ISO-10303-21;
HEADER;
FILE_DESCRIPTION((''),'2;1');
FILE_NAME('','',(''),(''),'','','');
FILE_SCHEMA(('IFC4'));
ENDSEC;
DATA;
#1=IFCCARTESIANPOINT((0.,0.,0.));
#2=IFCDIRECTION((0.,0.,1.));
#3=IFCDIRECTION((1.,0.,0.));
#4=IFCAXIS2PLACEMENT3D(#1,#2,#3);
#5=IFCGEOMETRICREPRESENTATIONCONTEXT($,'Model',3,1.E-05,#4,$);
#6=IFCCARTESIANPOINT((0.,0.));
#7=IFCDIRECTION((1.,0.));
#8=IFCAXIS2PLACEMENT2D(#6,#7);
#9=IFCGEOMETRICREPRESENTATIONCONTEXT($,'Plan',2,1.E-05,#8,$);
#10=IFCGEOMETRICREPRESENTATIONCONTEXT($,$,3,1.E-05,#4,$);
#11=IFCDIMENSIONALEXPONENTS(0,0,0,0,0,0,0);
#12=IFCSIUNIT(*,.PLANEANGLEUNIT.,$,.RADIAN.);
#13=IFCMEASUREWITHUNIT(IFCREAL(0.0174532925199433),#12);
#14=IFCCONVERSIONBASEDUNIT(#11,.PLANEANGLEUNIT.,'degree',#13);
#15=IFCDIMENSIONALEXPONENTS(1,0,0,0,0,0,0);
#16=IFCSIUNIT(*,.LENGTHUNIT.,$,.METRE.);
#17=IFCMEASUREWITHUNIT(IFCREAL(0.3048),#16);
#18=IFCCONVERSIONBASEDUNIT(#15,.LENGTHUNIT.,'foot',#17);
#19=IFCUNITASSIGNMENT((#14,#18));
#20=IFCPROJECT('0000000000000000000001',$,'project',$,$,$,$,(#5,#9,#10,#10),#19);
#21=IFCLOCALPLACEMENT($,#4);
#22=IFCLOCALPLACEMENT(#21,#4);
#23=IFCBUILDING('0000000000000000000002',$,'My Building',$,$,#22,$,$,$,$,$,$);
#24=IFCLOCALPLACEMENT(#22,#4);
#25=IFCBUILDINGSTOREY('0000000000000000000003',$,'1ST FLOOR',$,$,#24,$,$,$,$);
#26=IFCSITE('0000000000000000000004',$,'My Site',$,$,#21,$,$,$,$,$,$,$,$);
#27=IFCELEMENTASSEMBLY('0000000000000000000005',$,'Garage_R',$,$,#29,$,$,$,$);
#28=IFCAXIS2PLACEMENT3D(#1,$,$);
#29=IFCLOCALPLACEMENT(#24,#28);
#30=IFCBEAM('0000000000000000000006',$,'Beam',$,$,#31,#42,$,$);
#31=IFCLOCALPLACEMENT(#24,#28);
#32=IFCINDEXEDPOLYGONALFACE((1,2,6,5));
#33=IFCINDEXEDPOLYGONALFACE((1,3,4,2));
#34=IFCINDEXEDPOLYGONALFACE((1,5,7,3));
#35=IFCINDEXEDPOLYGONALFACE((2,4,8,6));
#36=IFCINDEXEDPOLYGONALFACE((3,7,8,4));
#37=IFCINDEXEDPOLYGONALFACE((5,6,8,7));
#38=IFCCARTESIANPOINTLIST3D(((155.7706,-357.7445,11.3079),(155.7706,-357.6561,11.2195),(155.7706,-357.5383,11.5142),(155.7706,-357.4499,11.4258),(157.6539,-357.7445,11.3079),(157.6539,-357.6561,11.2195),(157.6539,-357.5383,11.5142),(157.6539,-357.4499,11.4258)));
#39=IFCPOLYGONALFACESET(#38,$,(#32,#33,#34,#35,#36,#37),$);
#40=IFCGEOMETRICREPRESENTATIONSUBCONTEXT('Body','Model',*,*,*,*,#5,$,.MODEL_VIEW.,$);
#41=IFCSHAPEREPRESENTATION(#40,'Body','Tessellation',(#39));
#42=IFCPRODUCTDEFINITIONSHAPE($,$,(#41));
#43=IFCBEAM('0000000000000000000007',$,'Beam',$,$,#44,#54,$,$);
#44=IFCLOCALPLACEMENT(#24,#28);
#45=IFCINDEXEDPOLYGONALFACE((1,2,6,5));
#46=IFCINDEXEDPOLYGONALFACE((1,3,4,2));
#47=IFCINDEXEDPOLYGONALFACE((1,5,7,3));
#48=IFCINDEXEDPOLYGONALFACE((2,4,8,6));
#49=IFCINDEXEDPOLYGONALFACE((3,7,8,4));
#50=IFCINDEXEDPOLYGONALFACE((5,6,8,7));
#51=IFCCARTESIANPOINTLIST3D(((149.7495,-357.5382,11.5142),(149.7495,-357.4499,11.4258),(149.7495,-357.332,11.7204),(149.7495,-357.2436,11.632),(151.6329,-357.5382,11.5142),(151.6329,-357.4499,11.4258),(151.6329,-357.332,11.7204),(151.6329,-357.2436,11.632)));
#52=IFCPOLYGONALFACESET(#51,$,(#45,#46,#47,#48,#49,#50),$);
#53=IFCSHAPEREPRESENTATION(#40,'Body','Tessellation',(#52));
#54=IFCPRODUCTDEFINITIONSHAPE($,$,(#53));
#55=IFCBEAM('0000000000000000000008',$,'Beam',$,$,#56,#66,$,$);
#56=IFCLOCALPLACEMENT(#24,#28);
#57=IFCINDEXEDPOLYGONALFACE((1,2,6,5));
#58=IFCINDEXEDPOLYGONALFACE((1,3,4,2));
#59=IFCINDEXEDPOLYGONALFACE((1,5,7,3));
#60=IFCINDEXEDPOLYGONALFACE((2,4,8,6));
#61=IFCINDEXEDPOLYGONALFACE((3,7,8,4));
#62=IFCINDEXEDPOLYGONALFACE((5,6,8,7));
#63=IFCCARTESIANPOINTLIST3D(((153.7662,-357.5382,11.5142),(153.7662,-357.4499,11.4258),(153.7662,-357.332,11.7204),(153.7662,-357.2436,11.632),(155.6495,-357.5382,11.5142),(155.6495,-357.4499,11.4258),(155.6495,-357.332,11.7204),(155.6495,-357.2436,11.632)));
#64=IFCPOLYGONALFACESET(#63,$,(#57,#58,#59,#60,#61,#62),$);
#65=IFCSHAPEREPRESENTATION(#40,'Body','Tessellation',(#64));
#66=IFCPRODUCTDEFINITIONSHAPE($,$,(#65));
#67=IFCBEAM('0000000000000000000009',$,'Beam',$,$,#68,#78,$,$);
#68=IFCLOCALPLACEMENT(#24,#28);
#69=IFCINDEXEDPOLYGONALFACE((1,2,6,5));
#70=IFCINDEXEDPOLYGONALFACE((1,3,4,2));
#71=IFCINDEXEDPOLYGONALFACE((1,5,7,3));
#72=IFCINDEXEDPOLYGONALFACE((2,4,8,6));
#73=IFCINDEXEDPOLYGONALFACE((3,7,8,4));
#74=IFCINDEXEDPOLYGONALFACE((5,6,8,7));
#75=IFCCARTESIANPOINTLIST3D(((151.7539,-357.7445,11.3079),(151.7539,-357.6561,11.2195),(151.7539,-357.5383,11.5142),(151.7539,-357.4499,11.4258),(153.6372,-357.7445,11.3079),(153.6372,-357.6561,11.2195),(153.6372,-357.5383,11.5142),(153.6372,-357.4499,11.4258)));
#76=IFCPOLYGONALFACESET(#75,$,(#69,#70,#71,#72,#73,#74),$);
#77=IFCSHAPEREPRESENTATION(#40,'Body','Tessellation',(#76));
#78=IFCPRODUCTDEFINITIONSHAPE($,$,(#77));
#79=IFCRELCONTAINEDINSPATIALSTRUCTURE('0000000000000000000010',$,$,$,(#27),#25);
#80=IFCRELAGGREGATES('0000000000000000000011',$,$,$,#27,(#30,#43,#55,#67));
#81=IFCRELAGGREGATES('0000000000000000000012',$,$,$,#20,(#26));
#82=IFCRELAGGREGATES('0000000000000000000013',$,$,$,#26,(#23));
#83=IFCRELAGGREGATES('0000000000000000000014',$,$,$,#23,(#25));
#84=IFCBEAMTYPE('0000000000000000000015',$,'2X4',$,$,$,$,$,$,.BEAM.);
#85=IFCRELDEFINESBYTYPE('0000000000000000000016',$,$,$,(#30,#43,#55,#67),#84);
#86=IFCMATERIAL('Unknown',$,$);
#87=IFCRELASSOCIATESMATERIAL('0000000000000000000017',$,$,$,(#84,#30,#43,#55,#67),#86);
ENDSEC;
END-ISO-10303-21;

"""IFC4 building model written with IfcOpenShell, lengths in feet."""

from ifc_helpers import new_model, entity, si_unit, converted_unit, frame, origin_with_axes, origin_2d_with_axis, place, context, subcontext, project, spatial, rectangle, extrude, material, material_profile, profile_set, profile_usage, type_object, element, aggregate, save


model = new_model("IFC4")

# Units and contexts
model_context = context("Model", 3, precision=1e-05, world=origin_with_axes())
plan_context = context("Plan", 2, precision=1e-05, world=origin_2d_with_axis())
context_of_model = context(None, 3, precision=1e-05, world=origin_with_axes())
body_context = subcontext(model_context, "Body", "Model", "MODEL_VIEW")
ifc_project = project(units=[converted_unit("PLANEANGLEUNIT", "degree", entity("IfcReal", 0.0174532925199433), si_unit("PLANEANGLEUNIT", "RADIAN"), dimensions=[0, 0, 0, 0, 0, 0, 0]), converted_unit("LENGTHUNIT", "foot", entity("IfcReal", 0.3048), si_unit("LENGTHUNIT", "METRE"), dimensions=[1, 0, 0, 0, 0, 0, 0])], contexts=[model_context, plan_context, context_of_model, context_of_model])

# Site, building, storey
site_placement = place(None, origin_with_axes())
site = spatial("IfcSite", under=ifc_project, at=site_placement, Name="My Site")
building_placement = place(site_placement, origin_with_axes())
building = spatial("IfcBuilding", under=site, at=building_placement, Name="My Building")
storey_placement = place(building_placement, origin_with_axes())
storey = spatial("IfcBuildingStorey", under=building, at=storey_placement, Name="1ST FLOOR")

# Element assembly, beams
ifc_material_1 = material(Name="Unknown")
ifc_material_profile_1 = material_profile(ifc_material_1, rectangle(XDim=0.125, YDim=0.2917))
ifc_profile_set_1 = profile_set([ifc_material_profile_1])
beam_type_1 = type_object("IfcBeamType", Name="2X4", PredefinedType="BEAM", material=ifc_profile_set_1)
assembly_1_placement = place(storey_placement, origin_with_axes())
assembly_1 = element("IfcElementAssembly", 1, at=assembly_1_placement, inside=storey, Name="Garage_R")
ifc_profile_usage_1 = profile_usage(ifc_profile_set_1, cardinal=5)
beam_1_placement = place(assembly_1_placement, frame((155.7706, -357.5972, 11.3668), z_axis=(1.0, -0.000001, 0.0), x_axis=(0.0, -0.707107, 0.707107)))
beam_1 = element("IfcBeam", 2, at=beam_1_placement, type_object=beam_type_1, material=ifc_profile_usage_1, Name="Beam", context=body_context, shape_type="SweptSolid", body=[
    extrude(rectangle(XDim=0.125, YDim=0.2917), origin_with_axes(), (0.0, 0.0, 1.0), 1.8833),
])
ifc_profile_usage_2 = profile_usage(ifc_profile_set_1, cardinal=5)
beam_2_placement = place(assembly_1_placement, frame((149.7495, -357.3909, 11.5731), z_axis=(1.0, -0.000001, 0.0), x_axis=(0.0, -0.707107, 0.707107)))
beam_2 = element("IfcBeam", 3, at=beam_2_placement, type_object=beam_type_1, material=ifc_profile_usage_2, Name="Beam", context=body_context, shape_type="SweptSolid", body=[
    extrude(rectangle(XDim=0.125, YDim=0.2917), origin_with_axes(), (0.0, 0.0, 1.0), 1.8833),
])
ifc_profile_usage_3 = profile_usage(ifc_profile_set_1, cardinal=5)
beam_3_placement = place(assembly_1_placement, frame((153.7662, -357.3909, 11.5731), z_axis=(1.0, -0.000001, 0.0), x_axis=(0.0, -0.707107, 0.707107)))
beam_3 = element("IfcBeam", 4, at=beam_3_placement, type_object=beam_type_1, material=ifc_profile_usage_3, Name="Beam", context=body_context, shape_type="SweptSolid", body=[
    extrude(rectangle(XDim=0.125, YDim=0.2917), origin_with_axes(), (0.0, 0.0, 1.0), 1.8833),
])
ifc_profile_usage_4 = profile_usage(ifc_profile_set_1, cardinal=5)
beam_4_placement = place(assembly_1_placement, frame((151.7539, -357.5972, 11.3668), z_axis=(1.0, -0.000001, 0.0), x_axis=(0.0, -0.707107, 0.707107)))
beam_4 = element("IfcBeam", 5, at=beam_4_placement, type_object=beam_type_1, material=ifc_profile_usage_4, Name="Beam", context=body_context, shape_type="SweptSolid", body=[
    extrude(rectangle(XDim=0.125, YDim=0.2917), origin_with_axes(), (0.0, 0.0, 1.0), 1.8833),
])
aggregate(assembly_1, [beam_1, beam_2, beam_3, beam_4])

save(model, "model.ifc")
